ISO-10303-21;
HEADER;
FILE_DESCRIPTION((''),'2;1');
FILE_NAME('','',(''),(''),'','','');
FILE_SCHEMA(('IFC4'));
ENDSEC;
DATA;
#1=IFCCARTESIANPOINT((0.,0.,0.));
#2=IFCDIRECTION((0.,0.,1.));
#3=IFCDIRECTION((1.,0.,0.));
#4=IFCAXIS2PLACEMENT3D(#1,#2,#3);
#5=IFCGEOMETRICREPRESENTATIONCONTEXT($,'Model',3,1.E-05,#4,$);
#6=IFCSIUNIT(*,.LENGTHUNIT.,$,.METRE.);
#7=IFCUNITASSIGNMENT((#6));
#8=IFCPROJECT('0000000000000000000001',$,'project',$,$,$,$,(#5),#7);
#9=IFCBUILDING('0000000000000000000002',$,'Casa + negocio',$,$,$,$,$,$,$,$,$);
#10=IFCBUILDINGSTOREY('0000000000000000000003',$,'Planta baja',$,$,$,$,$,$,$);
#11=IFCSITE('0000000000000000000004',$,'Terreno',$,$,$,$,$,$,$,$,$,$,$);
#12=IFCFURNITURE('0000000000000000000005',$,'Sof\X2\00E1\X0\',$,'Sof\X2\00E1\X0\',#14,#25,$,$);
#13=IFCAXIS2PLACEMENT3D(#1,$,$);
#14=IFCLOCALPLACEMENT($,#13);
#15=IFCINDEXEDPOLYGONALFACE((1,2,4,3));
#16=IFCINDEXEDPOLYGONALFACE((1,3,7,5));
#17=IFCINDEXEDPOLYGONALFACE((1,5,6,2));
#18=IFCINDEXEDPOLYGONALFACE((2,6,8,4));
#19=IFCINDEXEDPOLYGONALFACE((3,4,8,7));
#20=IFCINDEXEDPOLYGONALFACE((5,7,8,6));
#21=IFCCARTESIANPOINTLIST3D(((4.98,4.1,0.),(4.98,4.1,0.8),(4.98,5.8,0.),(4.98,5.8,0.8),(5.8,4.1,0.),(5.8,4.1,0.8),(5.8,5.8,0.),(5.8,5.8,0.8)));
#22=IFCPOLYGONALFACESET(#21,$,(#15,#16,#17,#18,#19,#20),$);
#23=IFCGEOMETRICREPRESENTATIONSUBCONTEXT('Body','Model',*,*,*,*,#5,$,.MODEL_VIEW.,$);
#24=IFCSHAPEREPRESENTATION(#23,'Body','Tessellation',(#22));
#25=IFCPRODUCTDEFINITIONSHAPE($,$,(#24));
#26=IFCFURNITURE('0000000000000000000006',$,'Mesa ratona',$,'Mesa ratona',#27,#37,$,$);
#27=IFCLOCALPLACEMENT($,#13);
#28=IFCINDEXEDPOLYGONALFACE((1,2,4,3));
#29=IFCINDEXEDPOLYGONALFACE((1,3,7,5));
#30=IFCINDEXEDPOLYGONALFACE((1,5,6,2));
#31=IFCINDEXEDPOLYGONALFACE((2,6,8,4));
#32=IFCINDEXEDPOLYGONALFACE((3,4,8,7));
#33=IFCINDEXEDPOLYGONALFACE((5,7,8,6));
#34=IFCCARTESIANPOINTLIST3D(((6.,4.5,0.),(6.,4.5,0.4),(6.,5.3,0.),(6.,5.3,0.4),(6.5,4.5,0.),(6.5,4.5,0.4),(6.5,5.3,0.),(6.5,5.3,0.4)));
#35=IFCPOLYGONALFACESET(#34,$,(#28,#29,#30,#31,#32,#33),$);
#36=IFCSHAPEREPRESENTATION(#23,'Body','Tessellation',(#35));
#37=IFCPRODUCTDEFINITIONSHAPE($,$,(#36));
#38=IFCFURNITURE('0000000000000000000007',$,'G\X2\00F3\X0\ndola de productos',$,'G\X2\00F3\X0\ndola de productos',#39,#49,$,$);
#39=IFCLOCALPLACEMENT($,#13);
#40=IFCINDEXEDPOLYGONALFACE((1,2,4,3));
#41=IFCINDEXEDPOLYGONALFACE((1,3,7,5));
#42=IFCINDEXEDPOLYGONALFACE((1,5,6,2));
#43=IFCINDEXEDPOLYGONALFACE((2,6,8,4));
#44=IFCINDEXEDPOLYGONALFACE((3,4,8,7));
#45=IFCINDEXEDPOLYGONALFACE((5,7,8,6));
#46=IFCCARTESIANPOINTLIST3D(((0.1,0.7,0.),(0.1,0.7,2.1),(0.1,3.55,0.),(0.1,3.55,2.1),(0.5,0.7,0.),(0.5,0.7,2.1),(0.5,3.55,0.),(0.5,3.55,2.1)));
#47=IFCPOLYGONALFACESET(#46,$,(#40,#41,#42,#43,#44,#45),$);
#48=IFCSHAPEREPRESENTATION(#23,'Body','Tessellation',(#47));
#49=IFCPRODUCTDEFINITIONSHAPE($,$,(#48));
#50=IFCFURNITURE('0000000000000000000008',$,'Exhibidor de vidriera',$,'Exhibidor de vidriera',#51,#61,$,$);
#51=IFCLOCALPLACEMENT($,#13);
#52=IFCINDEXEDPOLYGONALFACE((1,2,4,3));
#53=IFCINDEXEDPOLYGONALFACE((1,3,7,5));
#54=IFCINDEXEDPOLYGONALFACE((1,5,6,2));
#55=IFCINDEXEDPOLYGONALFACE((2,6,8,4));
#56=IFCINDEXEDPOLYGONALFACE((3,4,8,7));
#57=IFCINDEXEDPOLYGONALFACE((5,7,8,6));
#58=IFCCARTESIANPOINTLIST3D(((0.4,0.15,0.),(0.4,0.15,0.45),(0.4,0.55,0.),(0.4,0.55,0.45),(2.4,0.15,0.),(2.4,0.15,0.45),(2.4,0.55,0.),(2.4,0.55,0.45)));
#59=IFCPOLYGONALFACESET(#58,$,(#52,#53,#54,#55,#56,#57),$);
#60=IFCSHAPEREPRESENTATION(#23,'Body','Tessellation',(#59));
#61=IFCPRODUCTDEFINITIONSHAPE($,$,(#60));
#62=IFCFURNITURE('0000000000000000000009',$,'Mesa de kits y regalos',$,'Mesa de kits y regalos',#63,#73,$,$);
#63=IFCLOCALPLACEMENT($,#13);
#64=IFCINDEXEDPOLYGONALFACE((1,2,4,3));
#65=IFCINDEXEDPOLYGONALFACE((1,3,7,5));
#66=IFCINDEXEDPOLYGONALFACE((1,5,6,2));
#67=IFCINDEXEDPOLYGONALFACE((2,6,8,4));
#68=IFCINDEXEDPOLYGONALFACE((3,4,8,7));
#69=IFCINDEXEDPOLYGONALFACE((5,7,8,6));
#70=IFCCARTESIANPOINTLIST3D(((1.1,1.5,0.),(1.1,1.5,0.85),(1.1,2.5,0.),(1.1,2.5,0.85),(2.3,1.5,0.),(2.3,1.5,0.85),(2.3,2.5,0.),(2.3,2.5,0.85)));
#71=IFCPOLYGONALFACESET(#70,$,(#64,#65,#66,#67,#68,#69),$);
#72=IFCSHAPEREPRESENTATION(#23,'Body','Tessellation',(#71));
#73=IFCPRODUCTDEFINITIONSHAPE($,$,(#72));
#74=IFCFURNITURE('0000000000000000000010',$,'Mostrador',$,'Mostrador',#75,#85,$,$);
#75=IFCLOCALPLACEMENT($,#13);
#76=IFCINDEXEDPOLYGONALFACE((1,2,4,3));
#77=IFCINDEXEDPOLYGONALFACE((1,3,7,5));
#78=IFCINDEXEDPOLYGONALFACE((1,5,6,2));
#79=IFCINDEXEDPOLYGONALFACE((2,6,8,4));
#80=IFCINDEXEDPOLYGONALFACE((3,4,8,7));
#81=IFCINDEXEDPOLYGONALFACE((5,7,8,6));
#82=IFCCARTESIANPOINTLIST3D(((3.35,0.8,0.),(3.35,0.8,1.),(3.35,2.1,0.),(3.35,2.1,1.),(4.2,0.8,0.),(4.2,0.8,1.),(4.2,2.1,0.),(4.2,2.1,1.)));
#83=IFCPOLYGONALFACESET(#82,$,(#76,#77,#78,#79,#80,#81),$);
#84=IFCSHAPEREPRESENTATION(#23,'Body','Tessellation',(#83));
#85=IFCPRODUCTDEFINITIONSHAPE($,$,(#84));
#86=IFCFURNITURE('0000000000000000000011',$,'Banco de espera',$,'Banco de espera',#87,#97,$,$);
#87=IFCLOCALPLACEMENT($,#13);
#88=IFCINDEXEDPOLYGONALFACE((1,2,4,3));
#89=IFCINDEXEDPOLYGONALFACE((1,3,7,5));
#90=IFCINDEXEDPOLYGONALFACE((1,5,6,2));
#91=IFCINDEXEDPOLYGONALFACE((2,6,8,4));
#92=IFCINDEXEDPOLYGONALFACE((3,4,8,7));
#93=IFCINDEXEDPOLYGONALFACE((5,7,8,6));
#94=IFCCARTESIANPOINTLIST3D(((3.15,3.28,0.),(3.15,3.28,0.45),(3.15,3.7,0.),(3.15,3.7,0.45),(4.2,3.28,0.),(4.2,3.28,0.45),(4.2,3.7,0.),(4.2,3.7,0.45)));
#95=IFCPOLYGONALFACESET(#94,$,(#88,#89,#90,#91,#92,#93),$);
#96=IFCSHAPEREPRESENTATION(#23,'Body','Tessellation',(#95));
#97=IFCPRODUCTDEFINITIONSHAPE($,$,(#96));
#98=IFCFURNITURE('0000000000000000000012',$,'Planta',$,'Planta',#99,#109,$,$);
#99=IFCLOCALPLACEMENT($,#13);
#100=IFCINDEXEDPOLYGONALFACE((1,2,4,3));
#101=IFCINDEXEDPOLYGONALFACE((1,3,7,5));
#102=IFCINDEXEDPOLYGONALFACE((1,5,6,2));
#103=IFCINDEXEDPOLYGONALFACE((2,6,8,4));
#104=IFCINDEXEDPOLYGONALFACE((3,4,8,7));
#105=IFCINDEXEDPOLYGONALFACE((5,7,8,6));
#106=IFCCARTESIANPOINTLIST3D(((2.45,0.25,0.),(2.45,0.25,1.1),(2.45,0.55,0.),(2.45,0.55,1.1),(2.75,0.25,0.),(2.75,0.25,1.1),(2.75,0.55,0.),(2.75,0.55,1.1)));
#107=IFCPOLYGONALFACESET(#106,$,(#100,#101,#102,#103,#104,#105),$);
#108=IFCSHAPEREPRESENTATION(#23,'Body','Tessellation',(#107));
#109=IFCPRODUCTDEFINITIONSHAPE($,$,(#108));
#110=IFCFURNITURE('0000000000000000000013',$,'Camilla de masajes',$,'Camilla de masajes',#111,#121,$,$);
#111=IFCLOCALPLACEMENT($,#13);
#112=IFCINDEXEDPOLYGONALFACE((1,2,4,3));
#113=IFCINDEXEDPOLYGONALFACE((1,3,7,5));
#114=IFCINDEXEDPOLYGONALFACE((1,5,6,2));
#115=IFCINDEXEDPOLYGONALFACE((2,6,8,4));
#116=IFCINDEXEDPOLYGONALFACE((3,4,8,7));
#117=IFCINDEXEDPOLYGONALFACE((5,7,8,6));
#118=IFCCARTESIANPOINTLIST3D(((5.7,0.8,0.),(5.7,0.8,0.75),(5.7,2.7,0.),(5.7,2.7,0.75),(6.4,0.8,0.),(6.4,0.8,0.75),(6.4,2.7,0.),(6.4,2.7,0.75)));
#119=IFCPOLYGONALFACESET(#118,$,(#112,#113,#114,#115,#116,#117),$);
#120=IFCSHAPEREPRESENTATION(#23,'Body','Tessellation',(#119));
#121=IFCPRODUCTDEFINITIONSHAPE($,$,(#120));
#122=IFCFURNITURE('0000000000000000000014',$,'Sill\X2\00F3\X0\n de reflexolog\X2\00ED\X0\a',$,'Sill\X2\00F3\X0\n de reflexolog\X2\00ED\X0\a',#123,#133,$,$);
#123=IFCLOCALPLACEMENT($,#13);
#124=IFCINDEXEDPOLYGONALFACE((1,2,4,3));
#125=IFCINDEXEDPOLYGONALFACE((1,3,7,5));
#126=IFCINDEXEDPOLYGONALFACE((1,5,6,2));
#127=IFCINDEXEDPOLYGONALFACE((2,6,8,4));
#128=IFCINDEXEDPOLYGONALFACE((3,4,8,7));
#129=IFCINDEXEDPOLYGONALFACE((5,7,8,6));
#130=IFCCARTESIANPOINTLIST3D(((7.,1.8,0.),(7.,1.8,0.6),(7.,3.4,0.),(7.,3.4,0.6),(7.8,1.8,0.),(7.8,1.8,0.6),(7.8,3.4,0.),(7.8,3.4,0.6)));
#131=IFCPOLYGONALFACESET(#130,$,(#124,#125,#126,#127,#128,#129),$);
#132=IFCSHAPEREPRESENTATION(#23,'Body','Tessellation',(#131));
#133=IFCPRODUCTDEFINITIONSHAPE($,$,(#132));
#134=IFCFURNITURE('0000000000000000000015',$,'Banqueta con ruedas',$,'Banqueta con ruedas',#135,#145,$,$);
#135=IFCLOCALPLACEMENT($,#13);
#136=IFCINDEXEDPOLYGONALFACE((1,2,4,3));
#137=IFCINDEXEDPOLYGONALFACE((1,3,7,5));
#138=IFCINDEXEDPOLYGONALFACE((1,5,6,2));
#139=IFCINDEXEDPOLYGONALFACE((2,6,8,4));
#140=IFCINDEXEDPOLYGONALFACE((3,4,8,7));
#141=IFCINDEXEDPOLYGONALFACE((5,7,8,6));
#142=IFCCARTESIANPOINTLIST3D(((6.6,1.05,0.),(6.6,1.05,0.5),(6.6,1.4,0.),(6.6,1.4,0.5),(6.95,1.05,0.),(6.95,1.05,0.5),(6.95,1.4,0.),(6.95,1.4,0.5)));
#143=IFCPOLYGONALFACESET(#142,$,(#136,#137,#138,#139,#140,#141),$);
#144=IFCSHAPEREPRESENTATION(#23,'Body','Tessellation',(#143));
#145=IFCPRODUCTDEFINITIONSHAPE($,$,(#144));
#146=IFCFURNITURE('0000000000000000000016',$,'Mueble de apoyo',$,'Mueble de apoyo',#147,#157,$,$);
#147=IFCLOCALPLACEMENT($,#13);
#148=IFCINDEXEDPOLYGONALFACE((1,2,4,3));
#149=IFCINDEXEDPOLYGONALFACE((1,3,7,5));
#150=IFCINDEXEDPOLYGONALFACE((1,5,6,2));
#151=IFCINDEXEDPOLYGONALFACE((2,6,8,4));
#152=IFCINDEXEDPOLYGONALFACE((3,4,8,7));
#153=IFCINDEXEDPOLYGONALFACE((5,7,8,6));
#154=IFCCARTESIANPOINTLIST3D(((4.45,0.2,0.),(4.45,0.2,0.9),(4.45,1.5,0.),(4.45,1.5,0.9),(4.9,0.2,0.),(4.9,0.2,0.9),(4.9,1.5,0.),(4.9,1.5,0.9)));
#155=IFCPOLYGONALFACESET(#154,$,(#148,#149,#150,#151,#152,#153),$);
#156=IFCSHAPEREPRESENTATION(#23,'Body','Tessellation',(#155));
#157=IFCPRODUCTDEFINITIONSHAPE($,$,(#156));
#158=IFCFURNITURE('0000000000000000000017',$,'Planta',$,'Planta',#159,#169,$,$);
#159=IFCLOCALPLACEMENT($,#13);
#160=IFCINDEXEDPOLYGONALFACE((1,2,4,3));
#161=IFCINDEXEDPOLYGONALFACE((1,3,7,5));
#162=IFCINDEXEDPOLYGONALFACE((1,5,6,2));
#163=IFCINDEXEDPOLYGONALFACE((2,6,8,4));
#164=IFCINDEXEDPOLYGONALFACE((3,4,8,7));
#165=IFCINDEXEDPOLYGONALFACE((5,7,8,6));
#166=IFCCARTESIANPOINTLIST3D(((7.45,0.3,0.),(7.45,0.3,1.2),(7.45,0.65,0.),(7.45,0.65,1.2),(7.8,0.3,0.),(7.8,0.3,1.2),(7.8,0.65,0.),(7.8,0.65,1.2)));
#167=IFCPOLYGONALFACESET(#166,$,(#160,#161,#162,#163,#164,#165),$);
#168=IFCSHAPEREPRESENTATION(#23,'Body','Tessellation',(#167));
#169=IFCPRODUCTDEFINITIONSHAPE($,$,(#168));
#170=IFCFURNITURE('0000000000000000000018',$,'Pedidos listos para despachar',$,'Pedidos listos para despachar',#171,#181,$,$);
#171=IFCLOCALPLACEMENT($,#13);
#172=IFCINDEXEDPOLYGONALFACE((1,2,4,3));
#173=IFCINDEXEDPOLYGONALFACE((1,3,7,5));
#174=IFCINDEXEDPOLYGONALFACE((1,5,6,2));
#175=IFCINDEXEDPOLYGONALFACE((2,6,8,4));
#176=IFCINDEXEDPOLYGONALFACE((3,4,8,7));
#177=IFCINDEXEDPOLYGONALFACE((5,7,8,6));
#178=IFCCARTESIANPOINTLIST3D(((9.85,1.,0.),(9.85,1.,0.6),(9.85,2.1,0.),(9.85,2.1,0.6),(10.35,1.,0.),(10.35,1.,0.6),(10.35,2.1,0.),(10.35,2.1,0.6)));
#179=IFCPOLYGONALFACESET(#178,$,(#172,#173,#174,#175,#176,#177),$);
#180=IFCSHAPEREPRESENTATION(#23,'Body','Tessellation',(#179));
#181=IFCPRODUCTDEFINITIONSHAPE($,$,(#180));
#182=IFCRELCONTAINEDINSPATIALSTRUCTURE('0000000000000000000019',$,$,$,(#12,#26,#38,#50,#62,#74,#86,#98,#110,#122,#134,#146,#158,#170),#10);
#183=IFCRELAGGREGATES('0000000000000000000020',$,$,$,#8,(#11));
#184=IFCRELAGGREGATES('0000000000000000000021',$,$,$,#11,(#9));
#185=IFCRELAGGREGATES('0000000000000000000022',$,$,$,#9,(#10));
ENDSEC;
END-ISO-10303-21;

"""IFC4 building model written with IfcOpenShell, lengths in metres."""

from ifc_helpers import new_model, si_unit, frame, origin_with_axes, place, context, subcontext, project, spatial, line, indexed_curve, outline, extrude, element, save


model = new_model("IFC4")

# Units and contexts
model_context = context("Model", 3, precision=1e-05, world=origin_with_axes())
body_context = subcontext(model_context, "Body", "Model", "MODEL_VIEW")
ifc_project = project(units=[si_unit("LENGTHUNIT", "METRE")], contexts=[model_context])

# Site, building, storey
site = spatial("IfcSite", under=ifc_project, Name="Terreno")
building = spatial("IfcBuilding", under=site, Name="Casa + negocio")
storey = spatial("IfcBuildingStorey", under=building, Name="Planta baja")

# Furniture
furniture_1_placement = place(None, frame((4.98, 4.1, 0.0), z_axis=(0.0, 0.0, 1.0), x_axis=(1.0, 0.0, 0.0)))
element("IfcFurniture", 1, at=furniture_1_placement, inside=storey, Name="Sofá", ObjectType="Sofá", context=body_context, shape_type="SweptSolid", body=[
    extrude(outline(indexed_curve([(0.0, 0.0), (0.82, 0.0), (0.82, 1.7), (0.0, 1.7)], segments=[line(1, 2, 3, 4, 1)])), origin_with_axes(), (0.0, 0.0, 1.0), 0.8),
])
furniture_2_placement = place(None, frame((6.0, 4.5, 0.0), z_axis=(0.0, 0.0, 1.0), x_axis=(1.0, 0.0, 0.0)))
element("IfcFurniture", 2, at=furniture_2_placement, inside=storey, Name="Mesa ratona", ObjectType="Mesa ratona", context=body_context, shape_type="SweptSolid", body=[
    extrude(outline(indexed_curve([(0.0, 0.0), (0.5, 0.0), (0.5, 0.8), (0.0, 0.8)], segments=[line(1, 2, 3, 4, 1)])), origin_with_axes(), (0.0, 0.0, 1.0), 0.4),
])
furniture_3_placement = place(None, frame((0.1, 0.7, 0.0), z_axis=(0.0, 0.0, 1.0), x_axis=(1.0, 0.0, 0.0)))
element("IfcFurniture", 3, at=furniture_3_placement, inside=storey, Name="Góndola de productos", ObjectType="Góndola de productos", context=body_context, shape_type="SweptSolid", body=[
    extrude(outline(indexed_curve([(0.0, 0.0), (0.4, 0.0), (0.4, 2.85), (0.0, 2.85)], segments=[line(1, 2, 3, 4, 1)])), origin_with_axes(), (0.0, 0.0, 1.0), 2.1),
])
furniture_4_placement = place(None, frame((0.4, 0.15, 0.0), z_axis=(0.0, 0.0, 1.0), x_axis=(1.0, 0.0, 0.0)))
element("IfcFurniture", 4, at=furniture_4_placement, inside=storey, Name="Exhibidor de vidriera", ObjectType="Exhibidor de vidriera", context=body_context, shape_type="SweptSolid", body=[
    extrude(outline(indexed_curve([(0.0, 0.0), (2.0, 0.0), (2.0, 0.4), (0.0, 0.4)], segments=[line(1, 2, 3, 4, 1)])), origin_with_axes(), (0.0, 0.0, 1.0), 0.45),
])
furniture_5_placement = place(None, frame((1.1, 1.5, 0.0), z_axis=(0.0, 0.0, 1.0), x_axis=(1.0, 0.0, 0.0)))
element("IfcFurniture", 5, at=furniture_5_placement, inside=storey, Name="Mesa de kits y regalos", ObjectType="Mesa de kits y regalos", context=body_context, shape_type="SweptSolid", body=[
    extrude(outline(indexed_curve([(0.0, 0.0), (1.2, 0.0), (1.2, 1.0), (0.0, 1.0)], segments=[line(1, 2, 3, 4, 1)])), origin_with_axes(), (0.0, 0.0, 1.0), 0.85),
])
furniture_6_placement = place(None, frame((3.35, 0.8, 0.0), z_axis=(0.0, 0.0, 1.0), x_axis=(1.0, 0.0, 0.0)))
element("IfcFurniture", 6, at=furniture_6_placement, inside=storey, Name="Mostrador", ObjectType="Mostrador", context=body_context, shape_type="SweptSolid", body=[
    extrude(outline(indexed_curve([(0.0, 0.0), (0.85, 0.0), (0.85, 1.3), (0.0, 1.3)], segments=[line(1, 2, 3, 4, 1)])), origin_with_axes(), (0.0, 0.0, 1.0), 1.0),
])
furniture_7_placement = place(None, frame((3.15, 3.28, 0.0), z_axis=(0.0, 0.0, 1.0), x_axis=(1.0, 0.0, 0.0)))
element("IfcFurniture", 7, at=furniture_7_placement, inside=storey, Name="Banco de espera", ObjectType="Banco de espera", context=body_context, shape_type="SweptSolid", body=[
    extrude(outline(indexed_curve([(0.0, 0.0), (1.05, 0.0), (1.05, 0.42), (0.0, 0.42)], segments=[line(1, 2, 3, 4, 1)])), origin_with_axes(), (0.0, 0.0, 1.0), 0.45),
])
furniture_8_placement = place(None, frame((2.45, 0.25, 0.0), z_axis=(0.0, 0.0, 1.0), x_axis=(1.0, 0.0, 0.0)))
element("IfcFurniture", 8, at=furniture_8_placement, inside=storey, Name="Planta", ObjectType="Planta", context=body_context, shape_type="SweptSolid", body=[
    extrude(outline(indexed_curve([(0.0, 0.0), (0.3, 0.0), (0.3, 0.3), (0.0, 0.3)], segments=[line(1, 2, 3, 4, 1)])), origin_with_axes(), (0.0, 0.0, 1.0), 1.1),
])
furniture_9_placement = place(None, frame((5.7, 0.8, 0.0), z_axis=(0.0, 0.0, 1.0), x_axis=(1.0, 0.0, 0.0)))
element("IfcFurniture", 9, at=furniture_9_placement, inside=storey, Name="Camilla de masajes", ObjectType="Camilla de masajes", context=body_context, shape_type="SweptSolid", body=[
    extrude(outline(indexed_curve([(0.0, 0.0), (0.7, 0.0), (0.7, 1.9), (0.0, 1.9)], segments=[line(1, 2, 3, 4, 1)])), origin_with_axes(), (0.0, 0.0, 1.0), 0.75),
])
furniture_10_placement = place(None, frame((7.0, 1.8, 0.0), z_axis=(0.0, 0.0, 1.0), x_axis=(1.0, 0.0, 0.0)))
element("IfcFurniture", 10, at=furniture_10_placement, inside=storey, Name="Sillón de reflexología", ObjectType="Sillón de reflexología", context=body_context, shape_type="SweptSolid", body=[
    extrude(outline(indexed_curve([(0.0, 0.0), (0.8, 0.0), (0.8, 1.6), (0.0, 1.6)], segments=[line(1, 2, 3, 4, 1)])), origin_with_axes(), (0.0, 0.0, 1.0), 0.6),
])
furniture_11_placement = place(None, frame((6.6, 1.05, 0.0), z_axis=(0.0, 0.0, 1.0), x_axis=(1.0, 0.0, 0.0)))
element("IfcFurniture", 11, at=furniture_11_placement, inside=storey, Name="Banqueta con ruedas", ObjectType="Banqueta con ruedas", context=body_context, shape_type="SweptSolid", body=[
    extrude(outline(indexed_curve([(0.0, 0.0), (0.35, 0.0), (0.35, 0.35), (0.0, 0.35)], segments=[line(1, 2, 3, 4, 1)])), origin_with_axes(), (0.0, 0.0, 1.0), 0.5),
])
furniture_12_placement = place(None, frame((4.45, 0.2, 0.0), z_axis=(0.0, 0.0, 1.0), x_axis=(1.0, 0.0, 0.0)))
element("IfcFurniture", 12, at=furniture_12_placement, inside=storey, Name="Mueble de apoyo", ObjectType="Mueble de apoyo", context=body_context, shape_type="SweptSolid", body=[
    extrude(outline(indexed_curve([(0.0, 0.0), (0.45, 0.0), (0.45, 1.3), (0.0, 1.3)], segments=[line(1, 2, 3, 4, 1)])), origin_with_axes(), (0.0, 0.0, 1.0), 0.9),
])
furniture_13_placement = place(None, frame((7.45, 0.3, 0.0), z_axis=(0.0, 0.0, 1.0), x_axis=(1.0, 0.0, 0.0)))
element("IfcFurniture", 13, at=furniture_13_placement, inside=storey, Name="Planta", ObjectType="Planta", context=body_context, shape_type="SweptSolid", body=[
    extrude(outline(indexed_curve([(0.0, 0.0), (0.35, 0.0), (0.35, 0.35), (0.0, 0.35)], segments=[line(1, 2, 3, 4, 1)])), origin_with_axes(), (0.0, 0.0, 1.0), 1.2),
])
furniture_14_placement = place(None, frame((9.85, 1.0, 0.0), z_axis=(0.0, 0.0, 1.0), x_axis=(1.0, 0.0, 0.0)))
element("IfcFurniture", 14, at=furniture_14_placement, inside=storey, Name="Pedidos listos para despachar", ObjectType="Pedidos listos para despachar", context=body_context, shape_type="SweptSolid", body=[
    extrude(outline(indexed_curve([(0.0, 0.0), (0.5, 0.0), (0.5, 1.1), (0.0, 1.1)], segments=[line(1, 2, 3, 4, 1)])), origin_with_axes(), (0.0, 0.0, 1.0), 0.6),
])

save(model, "model.ifc")
